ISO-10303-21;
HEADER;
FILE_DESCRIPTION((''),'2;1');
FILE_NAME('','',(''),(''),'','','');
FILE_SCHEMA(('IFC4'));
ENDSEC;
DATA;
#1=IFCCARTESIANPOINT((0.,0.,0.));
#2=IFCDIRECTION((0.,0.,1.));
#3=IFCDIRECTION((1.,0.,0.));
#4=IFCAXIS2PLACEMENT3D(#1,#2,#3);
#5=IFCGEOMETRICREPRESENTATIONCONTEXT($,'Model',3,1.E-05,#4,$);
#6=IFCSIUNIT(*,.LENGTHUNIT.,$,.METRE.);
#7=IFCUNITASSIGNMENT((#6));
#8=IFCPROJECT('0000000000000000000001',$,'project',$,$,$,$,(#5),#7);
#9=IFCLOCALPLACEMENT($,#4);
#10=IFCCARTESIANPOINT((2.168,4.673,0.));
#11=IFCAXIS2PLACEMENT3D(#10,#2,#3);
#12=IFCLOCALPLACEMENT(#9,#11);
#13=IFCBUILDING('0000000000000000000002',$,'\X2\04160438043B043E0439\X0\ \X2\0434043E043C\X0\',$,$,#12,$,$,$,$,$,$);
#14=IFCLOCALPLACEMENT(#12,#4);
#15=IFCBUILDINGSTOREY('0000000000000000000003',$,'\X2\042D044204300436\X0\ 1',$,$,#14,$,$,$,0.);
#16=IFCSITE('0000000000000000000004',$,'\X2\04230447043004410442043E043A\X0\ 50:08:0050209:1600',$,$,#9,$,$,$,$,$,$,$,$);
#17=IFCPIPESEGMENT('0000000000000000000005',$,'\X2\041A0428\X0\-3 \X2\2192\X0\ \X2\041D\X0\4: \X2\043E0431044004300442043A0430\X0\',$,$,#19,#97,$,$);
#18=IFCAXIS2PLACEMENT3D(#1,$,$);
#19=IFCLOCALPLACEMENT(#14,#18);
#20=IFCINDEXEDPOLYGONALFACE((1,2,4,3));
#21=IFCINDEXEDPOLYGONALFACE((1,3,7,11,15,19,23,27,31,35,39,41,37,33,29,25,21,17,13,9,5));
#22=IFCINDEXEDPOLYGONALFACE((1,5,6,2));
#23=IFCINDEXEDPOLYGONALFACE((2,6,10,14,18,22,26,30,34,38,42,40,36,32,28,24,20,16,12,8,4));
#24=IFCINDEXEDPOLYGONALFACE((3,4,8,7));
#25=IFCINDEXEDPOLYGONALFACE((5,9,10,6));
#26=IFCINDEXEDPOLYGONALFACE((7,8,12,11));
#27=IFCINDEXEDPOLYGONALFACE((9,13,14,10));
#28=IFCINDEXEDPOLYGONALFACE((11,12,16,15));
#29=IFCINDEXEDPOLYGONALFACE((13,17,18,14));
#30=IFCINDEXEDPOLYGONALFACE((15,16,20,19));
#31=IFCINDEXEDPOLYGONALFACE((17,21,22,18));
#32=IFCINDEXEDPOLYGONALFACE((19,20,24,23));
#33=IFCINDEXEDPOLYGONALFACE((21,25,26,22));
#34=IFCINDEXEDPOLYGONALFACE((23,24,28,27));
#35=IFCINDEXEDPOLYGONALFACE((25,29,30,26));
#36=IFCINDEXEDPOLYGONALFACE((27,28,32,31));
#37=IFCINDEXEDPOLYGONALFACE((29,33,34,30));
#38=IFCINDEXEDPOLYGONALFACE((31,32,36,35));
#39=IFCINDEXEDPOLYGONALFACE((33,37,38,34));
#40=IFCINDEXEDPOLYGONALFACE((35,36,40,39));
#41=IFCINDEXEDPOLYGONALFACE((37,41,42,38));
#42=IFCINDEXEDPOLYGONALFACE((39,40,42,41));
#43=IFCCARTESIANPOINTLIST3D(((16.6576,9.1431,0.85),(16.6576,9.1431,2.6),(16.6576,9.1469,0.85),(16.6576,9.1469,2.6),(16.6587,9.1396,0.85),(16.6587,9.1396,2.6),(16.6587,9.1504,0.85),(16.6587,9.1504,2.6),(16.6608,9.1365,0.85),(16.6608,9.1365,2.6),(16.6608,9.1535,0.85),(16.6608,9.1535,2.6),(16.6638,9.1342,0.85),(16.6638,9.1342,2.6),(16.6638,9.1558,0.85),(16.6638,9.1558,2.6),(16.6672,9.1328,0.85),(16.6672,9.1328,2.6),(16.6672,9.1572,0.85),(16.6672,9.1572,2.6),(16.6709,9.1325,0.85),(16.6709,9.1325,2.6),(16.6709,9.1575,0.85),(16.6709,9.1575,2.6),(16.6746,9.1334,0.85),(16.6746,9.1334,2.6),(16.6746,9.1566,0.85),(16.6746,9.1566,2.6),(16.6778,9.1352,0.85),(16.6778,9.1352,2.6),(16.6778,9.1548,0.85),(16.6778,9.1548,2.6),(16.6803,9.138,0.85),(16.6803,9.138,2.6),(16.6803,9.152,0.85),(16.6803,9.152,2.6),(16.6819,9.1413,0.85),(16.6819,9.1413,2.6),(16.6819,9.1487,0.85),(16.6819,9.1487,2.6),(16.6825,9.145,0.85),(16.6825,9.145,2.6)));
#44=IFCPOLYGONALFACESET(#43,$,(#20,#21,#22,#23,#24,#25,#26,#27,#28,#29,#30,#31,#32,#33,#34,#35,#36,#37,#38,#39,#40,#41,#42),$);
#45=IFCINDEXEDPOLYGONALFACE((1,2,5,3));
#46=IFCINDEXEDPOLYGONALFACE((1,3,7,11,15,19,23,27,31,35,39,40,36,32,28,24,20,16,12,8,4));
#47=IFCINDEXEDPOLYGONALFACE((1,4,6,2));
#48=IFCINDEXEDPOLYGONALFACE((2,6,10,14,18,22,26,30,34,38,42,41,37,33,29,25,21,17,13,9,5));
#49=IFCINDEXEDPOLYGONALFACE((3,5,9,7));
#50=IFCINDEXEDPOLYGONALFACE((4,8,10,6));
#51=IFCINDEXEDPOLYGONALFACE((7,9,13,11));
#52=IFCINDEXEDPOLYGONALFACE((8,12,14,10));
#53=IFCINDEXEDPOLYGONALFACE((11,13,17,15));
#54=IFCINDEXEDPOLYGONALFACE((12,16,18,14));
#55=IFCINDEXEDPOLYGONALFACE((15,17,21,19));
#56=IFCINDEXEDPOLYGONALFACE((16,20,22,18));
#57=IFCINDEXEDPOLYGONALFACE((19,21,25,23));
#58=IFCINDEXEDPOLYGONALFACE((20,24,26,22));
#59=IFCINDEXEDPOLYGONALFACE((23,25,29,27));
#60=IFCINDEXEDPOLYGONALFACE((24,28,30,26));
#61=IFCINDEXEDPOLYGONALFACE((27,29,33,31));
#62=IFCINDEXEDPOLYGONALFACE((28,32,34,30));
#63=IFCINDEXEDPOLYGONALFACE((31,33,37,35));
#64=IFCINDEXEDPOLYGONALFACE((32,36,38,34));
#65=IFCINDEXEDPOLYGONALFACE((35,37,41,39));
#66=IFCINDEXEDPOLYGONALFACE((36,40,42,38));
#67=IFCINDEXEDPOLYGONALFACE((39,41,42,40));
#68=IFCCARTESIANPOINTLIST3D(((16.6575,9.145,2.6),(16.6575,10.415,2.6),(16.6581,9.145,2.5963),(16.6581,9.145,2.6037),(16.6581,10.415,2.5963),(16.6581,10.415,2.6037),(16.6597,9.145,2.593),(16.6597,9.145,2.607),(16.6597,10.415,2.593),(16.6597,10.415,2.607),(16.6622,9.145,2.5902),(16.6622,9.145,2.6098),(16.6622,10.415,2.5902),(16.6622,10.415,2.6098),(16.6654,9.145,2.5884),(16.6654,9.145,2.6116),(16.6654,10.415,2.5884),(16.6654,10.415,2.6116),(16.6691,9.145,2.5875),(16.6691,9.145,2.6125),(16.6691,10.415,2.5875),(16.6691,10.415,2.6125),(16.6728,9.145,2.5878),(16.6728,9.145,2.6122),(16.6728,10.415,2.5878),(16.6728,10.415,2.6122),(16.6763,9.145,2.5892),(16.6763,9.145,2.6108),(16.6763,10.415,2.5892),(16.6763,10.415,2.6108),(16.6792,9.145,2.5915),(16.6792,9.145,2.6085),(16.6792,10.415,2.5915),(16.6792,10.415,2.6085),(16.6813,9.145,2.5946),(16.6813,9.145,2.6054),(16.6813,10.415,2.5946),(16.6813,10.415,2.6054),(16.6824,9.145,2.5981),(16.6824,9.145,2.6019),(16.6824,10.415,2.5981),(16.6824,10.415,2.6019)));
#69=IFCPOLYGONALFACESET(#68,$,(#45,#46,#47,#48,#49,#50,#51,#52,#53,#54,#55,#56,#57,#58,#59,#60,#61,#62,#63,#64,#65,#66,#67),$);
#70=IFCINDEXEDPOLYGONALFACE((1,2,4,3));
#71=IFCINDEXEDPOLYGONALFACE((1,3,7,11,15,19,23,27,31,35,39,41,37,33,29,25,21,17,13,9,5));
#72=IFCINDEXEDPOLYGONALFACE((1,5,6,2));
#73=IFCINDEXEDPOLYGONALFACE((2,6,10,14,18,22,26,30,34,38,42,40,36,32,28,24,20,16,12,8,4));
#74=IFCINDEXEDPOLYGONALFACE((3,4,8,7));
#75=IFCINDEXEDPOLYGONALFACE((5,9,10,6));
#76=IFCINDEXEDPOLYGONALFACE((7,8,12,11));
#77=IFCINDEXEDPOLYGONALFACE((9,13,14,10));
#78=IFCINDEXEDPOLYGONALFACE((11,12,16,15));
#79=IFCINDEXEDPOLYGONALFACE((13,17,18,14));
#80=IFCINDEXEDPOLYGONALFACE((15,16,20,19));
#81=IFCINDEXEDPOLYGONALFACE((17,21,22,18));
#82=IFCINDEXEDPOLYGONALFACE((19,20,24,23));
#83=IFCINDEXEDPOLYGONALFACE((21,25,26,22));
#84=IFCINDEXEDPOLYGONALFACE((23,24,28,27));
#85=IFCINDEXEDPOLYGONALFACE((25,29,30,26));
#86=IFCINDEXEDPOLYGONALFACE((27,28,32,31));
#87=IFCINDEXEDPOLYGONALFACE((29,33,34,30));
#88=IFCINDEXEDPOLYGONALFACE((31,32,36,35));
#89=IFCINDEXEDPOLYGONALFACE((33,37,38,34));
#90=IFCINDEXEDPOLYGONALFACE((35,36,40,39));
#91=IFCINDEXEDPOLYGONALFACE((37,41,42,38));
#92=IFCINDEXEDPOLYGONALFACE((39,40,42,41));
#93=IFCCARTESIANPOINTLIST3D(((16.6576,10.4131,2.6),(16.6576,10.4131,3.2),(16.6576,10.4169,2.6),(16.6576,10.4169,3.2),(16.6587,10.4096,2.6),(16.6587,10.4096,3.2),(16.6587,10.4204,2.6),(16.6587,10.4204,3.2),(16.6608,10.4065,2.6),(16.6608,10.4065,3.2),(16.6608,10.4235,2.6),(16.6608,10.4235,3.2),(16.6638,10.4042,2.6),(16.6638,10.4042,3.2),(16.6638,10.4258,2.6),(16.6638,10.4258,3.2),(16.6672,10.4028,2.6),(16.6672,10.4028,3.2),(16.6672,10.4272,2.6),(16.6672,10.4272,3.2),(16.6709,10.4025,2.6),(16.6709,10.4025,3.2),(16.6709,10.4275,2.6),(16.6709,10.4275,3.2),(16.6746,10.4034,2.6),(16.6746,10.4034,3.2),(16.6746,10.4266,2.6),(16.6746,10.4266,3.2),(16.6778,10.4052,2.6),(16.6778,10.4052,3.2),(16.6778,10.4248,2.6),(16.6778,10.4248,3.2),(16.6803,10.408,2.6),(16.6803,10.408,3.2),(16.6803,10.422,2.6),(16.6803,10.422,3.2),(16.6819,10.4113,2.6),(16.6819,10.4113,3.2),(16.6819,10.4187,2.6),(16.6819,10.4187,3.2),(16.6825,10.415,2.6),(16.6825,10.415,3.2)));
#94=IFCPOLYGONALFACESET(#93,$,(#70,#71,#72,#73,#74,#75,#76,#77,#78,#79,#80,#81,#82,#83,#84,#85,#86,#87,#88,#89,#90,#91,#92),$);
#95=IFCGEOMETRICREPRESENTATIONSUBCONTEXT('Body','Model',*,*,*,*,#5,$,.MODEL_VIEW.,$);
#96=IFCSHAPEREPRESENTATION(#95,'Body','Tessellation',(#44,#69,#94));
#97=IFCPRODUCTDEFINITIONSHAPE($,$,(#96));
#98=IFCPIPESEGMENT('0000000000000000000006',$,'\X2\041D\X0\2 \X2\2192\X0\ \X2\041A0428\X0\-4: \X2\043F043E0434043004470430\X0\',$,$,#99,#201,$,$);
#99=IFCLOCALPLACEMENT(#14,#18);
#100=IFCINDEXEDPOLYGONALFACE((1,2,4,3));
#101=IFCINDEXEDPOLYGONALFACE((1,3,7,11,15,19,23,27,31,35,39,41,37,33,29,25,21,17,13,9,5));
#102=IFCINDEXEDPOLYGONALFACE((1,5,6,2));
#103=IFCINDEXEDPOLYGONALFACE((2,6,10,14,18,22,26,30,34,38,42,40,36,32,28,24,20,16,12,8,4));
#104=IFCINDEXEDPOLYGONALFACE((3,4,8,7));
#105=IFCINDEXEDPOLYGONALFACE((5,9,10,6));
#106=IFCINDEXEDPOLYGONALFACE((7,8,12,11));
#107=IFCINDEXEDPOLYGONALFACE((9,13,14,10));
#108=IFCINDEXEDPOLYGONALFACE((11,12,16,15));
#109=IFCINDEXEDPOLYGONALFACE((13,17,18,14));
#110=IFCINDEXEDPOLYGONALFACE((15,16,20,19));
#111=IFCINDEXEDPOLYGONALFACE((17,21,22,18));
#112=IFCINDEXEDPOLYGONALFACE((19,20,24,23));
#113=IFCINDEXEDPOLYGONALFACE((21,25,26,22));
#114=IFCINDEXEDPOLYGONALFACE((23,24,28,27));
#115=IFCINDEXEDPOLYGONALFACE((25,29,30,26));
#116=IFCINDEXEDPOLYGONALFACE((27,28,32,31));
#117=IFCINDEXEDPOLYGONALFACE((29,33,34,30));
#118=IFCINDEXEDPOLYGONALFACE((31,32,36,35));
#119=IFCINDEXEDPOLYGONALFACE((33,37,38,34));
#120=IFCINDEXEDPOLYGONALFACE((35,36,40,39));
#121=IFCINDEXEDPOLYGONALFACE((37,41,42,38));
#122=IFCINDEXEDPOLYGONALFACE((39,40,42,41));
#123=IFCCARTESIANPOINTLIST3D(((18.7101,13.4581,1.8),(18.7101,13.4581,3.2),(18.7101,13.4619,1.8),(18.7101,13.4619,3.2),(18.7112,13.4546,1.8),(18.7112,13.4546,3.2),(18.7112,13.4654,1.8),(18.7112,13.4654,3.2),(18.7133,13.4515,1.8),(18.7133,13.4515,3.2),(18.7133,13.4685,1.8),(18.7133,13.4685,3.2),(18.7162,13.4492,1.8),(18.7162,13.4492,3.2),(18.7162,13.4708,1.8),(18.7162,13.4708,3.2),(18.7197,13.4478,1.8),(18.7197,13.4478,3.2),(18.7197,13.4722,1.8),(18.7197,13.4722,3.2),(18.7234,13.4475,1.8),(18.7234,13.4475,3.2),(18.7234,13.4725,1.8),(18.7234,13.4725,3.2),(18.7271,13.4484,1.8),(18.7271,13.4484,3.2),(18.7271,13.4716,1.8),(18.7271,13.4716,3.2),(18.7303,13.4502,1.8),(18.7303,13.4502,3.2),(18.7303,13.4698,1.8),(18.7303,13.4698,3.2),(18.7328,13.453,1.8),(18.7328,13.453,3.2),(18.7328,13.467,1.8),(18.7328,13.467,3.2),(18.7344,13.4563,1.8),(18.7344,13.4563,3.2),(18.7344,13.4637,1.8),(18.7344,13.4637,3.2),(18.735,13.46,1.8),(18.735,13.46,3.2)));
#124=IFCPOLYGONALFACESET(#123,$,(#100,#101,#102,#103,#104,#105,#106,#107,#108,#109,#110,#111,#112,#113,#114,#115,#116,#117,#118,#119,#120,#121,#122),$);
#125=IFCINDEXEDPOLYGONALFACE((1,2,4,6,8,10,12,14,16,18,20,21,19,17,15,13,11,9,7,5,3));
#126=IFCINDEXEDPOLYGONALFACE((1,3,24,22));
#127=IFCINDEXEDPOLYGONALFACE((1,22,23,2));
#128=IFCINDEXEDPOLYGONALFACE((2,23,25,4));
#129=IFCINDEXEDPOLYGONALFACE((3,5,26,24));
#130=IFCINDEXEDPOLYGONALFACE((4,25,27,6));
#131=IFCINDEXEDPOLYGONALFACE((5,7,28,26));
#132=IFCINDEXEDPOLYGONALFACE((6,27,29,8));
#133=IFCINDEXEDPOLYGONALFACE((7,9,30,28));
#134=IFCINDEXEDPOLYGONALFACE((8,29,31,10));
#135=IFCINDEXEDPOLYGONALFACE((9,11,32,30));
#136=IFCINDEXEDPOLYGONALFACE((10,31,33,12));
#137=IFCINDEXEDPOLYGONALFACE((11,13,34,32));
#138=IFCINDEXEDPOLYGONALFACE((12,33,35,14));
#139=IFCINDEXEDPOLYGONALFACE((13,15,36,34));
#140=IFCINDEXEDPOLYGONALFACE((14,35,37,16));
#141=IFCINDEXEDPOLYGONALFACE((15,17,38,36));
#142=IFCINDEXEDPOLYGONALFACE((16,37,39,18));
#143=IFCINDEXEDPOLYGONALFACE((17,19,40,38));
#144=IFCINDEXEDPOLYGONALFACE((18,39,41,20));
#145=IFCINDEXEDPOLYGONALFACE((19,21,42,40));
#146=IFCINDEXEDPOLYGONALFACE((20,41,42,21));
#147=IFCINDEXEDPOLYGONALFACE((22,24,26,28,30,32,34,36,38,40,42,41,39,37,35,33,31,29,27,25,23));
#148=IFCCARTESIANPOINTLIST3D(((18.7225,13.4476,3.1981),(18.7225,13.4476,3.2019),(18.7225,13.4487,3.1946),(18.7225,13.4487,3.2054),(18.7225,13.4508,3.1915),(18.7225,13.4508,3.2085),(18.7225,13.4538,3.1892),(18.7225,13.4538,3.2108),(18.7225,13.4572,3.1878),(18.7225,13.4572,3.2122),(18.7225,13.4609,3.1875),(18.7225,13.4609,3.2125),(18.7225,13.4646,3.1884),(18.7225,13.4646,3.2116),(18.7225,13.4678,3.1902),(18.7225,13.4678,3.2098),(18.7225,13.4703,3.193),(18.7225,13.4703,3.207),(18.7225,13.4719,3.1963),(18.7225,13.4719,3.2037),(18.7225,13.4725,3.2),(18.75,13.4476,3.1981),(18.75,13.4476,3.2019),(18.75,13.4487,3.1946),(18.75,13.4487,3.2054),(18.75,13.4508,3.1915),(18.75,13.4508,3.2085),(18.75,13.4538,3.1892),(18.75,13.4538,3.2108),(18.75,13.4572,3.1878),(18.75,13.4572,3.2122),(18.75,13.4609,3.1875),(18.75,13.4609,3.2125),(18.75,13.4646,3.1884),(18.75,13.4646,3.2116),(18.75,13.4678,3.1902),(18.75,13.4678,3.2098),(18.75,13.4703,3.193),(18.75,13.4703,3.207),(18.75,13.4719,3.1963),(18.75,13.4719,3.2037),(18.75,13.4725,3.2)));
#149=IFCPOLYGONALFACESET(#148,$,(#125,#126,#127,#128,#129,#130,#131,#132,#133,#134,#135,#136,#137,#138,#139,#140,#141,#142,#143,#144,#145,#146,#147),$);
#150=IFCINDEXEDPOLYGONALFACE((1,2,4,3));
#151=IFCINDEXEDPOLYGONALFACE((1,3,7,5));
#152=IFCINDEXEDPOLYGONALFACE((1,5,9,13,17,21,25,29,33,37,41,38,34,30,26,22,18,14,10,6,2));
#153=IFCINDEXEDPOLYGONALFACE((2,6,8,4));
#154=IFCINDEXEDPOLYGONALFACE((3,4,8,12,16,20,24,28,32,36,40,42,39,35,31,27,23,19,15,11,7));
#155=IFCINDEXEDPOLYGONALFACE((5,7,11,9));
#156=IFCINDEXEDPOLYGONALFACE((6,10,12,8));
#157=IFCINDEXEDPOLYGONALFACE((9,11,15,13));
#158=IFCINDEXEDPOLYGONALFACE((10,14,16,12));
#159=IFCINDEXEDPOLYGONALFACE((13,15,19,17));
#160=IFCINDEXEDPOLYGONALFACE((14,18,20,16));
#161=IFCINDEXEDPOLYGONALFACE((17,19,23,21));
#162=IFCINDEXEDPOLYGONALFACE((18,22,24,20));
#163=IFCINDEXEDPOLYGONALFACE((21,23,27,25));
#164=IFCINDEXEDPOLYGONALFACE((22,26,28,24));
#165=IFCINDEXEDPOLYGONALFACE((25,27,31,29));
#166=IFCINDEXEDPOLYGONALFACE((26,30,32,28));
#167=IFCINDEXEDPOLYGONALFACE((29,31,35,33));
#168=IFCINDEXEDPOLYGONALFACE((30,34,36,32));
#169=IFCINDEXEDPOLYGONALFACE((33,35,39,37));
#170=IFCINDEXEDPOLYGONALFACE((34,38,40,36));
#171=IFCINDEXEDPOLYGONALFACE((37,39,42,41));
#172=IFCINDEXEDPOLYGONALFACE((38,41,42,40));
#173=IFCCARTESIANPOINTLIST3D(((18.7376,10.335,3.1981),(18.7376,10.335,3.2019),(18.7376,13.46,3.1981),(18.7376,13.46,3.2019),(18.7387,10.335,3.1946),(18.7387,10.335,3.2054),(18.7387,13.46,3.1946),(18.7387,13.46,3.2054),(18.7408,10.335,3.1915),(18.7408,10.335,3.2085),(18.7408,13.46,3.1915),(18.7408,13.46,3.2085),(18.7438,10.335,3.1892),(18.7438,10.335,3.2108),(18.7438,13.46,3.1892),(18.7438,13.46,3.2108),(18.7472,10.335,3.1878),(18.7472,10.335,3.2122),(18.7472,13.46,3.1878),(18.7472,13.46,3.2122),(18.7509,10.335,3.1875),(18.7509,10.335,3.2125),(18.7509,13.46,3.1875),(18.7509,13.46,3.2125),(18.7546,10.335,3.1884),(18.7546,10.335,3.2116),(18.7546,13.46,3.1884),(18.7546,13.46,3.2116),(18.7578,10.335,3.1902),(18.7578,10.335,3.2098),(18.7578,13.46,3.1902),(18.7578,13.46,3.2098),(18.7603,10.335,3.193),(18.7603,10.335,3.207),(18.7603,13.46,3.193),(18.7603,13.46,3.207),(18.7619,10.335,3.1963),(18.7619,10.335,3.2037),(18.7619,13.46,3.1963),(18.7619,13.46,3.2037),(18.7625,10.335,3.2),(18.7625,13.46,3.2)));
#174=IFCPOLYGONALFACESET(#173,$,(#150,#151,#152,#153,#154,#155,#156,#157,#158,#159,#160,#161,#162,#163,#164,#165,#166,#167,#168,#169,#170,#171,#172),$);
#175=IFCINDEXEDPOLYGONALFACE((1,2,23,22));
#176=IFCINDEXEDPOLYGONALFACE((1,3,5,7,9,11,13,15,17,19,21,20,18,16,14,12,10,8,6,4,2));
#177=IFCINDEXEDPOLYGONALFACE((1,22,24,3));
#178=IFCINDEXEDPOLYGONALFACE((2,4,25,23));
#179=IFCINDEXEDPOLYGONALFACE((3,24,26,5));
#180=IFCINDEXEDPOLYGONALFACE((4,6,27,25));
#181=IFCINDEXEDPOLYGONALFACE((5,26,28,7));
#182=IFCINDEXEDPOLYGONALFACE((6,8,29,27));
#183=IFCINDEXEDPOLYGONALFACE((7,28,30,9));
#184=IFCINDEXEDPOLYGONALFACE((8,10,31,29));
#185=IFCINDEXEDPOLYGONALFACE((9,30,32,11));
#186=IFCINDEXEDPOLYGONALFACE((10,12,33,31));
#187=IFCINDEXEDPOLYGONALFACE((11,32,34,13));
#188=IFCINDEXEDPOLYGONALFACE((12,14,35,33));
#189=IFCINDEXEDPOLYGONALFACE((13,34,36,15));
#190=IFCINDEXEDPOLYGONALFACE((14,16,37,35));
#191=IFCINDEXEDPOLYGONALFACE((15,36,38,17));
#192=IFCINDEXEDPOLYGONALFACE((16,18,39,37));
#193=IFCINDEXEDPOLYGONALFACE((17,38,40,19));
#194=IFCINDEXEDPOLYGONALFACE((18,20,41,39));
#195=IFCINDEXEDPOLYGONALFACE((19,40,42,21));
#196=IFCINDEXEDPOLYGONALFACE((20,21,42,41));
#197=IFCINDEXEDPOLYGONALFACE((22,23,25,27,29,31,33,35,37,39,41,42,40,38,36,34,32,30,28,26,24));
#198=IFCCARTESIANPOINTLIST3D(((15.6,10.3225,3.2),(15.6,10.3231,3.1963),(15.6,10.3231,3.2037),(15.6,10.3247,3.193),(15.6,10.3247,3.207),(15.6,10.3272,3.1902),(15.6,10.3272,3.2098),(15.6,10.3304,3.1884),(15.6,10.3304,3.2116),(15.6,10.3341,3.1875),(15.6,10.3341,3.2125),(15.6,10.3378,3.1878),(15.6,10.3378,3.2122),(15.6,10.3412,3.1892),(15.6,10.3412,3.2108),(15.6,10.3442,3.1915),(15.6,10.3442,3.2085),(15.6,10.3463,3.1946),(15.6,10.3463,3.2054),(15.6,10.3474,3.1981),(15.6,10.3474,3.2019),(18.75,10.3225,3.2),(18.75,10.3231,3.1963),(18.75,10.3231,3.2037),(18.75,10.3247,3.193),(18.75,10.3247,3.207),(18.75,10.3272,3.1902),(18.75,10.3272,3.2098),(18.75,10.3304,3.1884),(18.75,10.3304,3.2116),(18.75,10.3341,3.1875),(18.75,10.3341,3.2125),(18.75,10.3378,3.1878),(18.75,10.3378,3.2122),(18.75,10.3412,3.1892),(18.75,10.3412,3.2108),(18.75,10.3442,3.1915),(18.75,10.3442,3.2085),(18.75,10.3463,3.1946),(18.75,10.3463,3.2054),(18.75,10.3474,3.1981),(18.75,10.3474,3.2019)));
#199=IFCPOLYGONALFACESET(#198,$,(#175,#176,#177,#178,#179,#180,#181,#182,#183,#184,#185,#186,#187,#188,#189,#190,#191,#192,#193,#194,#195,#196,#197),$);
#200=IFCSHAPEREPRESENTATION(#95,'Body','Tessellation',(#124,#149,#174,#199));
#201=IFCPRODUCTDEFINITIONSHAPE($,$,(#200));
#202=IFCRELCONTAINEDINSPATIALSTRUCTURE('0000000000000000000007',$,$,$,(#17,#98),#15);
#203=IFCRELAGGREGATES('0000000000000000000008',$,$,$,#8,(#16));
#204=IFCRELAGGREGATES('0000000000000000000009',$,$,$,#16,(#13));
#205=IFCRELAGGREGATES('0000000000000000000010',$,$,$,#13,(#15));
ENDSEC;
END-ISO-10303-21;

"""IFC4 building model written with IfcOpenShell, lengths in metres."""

from ifc_helpers import new_model, si_unit, frame, origin_with_axes, origin_2d, place, context, subcontext, project, spatial, circle, extrude, element, save


model = new_model("IFC4")

# Units and contexts
model_context = context("Model", 3, precision=1e-05, world=origin_with_axes())
body_context = subcontext(model_context, "Body", "Model", "MODEL_VIEW")
ifc_project = project(units=[si_unit("LENGTHUNIT", "METRE")], contexts=[model_context])

# Site, building, storey
site_placement = place(None, origin_with_axes())
site = spatial("IfcSite", under=ifc_project, at=site_placement, Name="Участок 50:08:0050209:1600")
building_placement = place(site_placement, frame((2.168, 4.673, 0.0), z_axis=(0.0, 0.0, 1.0), x_axis=(1.0, 0.0, 0.0)))
building = spatial("IfcBuilding", under=site, at=building_placement, Name="Жилой дом")
storey_placement = place(building_placement, origin_with_axes())
storey = spatial("IfcBuildingStorey", under=building, at=storey_placement, Name="Этаж 1", Elevation=0.0)

# Pipe segments
pipe_segment_1_placement = place(storey_placement, origin_with_axes())
element("IfcPipeSegment", 1, at=pipe_segment_1_placement, inside=storey, Name="КШ-3 → Н4: обратка", context=body_context, shape_type="SweptSolid", body=[
    extrude(circle(Radius=0.0125, at=origin_2d()), frame((16.67, 9.145, 0.85), z_axis=(0.0, 0.0, 1.0), x_axis=(1.0, 0.0, 0.0)), (0.0, 0.0, 1.0), 1.75),
    extrude(circle(Radius=0.0125, at=origin_2d()), frame((16.67, 9.145, 2.6), z_axis=(0.0, 1.0, 0.0), x_axis=(-1.0, 0.0, 0.0)), (0.0, 0.0, 1.0), 1.27),
    extrude(circle(Radius=0.0125, at=origin_2d()), frame((16.67, 10.415, 2.6), z_axis=(0.0, 0.0, 1.0), x_axis=(1.0, 0.0, 0.0)), (0.0, 0.0, 1.0), 0.6),
])
pipe_segment_2_placement = place(storey_placement, origin_with_axes())
element("IfcPipeSegment", 2, at=pipe_segment_2_placement, inside=storey, Name="Н2 → КШ-4: подача", context=body_context, shape_type="SweptSolid", body=[
    extrude(circle(Radius=0.0125, at=origin_2d()), frame((18.7225, 13.46, 1.8), z_axis=(0.0, 0.0, 1.0), x_axis=(1.0, 0.0, 0.0)), (0.0, 0.0, 1.0), 1.4),
    extrude(circle(Radius=0.0125, at=origin_2d()), frame((18.7225, 13.46, 3.2), z_axis=(1.0, 0.0, 0.0), x_axis=(0.0, 1.0, 0.0)), (0.0, 0.0, 1.0), 0.0275),
    extrude(circle(Radius=0.0125, at=origin_2d()), frame((18.75, 13.46, 3.2), z_axis=(0.0, -1.0, 0.0), x_axis=(1.0, 0.0, 0.0)), (0.0, 0.0, 1.0), 3.125),
    extrude(circle(Radius=0.0125, at=origin_2d()), frame((18.75, 10.335, 3.2), z_axis=(-1.0, 0.0, 0.0), x_axis=(0.0, -1.0, 0.0)), (0.0, 0.0, 1.0), 3.15),
])

save(model, "model.ifc")
